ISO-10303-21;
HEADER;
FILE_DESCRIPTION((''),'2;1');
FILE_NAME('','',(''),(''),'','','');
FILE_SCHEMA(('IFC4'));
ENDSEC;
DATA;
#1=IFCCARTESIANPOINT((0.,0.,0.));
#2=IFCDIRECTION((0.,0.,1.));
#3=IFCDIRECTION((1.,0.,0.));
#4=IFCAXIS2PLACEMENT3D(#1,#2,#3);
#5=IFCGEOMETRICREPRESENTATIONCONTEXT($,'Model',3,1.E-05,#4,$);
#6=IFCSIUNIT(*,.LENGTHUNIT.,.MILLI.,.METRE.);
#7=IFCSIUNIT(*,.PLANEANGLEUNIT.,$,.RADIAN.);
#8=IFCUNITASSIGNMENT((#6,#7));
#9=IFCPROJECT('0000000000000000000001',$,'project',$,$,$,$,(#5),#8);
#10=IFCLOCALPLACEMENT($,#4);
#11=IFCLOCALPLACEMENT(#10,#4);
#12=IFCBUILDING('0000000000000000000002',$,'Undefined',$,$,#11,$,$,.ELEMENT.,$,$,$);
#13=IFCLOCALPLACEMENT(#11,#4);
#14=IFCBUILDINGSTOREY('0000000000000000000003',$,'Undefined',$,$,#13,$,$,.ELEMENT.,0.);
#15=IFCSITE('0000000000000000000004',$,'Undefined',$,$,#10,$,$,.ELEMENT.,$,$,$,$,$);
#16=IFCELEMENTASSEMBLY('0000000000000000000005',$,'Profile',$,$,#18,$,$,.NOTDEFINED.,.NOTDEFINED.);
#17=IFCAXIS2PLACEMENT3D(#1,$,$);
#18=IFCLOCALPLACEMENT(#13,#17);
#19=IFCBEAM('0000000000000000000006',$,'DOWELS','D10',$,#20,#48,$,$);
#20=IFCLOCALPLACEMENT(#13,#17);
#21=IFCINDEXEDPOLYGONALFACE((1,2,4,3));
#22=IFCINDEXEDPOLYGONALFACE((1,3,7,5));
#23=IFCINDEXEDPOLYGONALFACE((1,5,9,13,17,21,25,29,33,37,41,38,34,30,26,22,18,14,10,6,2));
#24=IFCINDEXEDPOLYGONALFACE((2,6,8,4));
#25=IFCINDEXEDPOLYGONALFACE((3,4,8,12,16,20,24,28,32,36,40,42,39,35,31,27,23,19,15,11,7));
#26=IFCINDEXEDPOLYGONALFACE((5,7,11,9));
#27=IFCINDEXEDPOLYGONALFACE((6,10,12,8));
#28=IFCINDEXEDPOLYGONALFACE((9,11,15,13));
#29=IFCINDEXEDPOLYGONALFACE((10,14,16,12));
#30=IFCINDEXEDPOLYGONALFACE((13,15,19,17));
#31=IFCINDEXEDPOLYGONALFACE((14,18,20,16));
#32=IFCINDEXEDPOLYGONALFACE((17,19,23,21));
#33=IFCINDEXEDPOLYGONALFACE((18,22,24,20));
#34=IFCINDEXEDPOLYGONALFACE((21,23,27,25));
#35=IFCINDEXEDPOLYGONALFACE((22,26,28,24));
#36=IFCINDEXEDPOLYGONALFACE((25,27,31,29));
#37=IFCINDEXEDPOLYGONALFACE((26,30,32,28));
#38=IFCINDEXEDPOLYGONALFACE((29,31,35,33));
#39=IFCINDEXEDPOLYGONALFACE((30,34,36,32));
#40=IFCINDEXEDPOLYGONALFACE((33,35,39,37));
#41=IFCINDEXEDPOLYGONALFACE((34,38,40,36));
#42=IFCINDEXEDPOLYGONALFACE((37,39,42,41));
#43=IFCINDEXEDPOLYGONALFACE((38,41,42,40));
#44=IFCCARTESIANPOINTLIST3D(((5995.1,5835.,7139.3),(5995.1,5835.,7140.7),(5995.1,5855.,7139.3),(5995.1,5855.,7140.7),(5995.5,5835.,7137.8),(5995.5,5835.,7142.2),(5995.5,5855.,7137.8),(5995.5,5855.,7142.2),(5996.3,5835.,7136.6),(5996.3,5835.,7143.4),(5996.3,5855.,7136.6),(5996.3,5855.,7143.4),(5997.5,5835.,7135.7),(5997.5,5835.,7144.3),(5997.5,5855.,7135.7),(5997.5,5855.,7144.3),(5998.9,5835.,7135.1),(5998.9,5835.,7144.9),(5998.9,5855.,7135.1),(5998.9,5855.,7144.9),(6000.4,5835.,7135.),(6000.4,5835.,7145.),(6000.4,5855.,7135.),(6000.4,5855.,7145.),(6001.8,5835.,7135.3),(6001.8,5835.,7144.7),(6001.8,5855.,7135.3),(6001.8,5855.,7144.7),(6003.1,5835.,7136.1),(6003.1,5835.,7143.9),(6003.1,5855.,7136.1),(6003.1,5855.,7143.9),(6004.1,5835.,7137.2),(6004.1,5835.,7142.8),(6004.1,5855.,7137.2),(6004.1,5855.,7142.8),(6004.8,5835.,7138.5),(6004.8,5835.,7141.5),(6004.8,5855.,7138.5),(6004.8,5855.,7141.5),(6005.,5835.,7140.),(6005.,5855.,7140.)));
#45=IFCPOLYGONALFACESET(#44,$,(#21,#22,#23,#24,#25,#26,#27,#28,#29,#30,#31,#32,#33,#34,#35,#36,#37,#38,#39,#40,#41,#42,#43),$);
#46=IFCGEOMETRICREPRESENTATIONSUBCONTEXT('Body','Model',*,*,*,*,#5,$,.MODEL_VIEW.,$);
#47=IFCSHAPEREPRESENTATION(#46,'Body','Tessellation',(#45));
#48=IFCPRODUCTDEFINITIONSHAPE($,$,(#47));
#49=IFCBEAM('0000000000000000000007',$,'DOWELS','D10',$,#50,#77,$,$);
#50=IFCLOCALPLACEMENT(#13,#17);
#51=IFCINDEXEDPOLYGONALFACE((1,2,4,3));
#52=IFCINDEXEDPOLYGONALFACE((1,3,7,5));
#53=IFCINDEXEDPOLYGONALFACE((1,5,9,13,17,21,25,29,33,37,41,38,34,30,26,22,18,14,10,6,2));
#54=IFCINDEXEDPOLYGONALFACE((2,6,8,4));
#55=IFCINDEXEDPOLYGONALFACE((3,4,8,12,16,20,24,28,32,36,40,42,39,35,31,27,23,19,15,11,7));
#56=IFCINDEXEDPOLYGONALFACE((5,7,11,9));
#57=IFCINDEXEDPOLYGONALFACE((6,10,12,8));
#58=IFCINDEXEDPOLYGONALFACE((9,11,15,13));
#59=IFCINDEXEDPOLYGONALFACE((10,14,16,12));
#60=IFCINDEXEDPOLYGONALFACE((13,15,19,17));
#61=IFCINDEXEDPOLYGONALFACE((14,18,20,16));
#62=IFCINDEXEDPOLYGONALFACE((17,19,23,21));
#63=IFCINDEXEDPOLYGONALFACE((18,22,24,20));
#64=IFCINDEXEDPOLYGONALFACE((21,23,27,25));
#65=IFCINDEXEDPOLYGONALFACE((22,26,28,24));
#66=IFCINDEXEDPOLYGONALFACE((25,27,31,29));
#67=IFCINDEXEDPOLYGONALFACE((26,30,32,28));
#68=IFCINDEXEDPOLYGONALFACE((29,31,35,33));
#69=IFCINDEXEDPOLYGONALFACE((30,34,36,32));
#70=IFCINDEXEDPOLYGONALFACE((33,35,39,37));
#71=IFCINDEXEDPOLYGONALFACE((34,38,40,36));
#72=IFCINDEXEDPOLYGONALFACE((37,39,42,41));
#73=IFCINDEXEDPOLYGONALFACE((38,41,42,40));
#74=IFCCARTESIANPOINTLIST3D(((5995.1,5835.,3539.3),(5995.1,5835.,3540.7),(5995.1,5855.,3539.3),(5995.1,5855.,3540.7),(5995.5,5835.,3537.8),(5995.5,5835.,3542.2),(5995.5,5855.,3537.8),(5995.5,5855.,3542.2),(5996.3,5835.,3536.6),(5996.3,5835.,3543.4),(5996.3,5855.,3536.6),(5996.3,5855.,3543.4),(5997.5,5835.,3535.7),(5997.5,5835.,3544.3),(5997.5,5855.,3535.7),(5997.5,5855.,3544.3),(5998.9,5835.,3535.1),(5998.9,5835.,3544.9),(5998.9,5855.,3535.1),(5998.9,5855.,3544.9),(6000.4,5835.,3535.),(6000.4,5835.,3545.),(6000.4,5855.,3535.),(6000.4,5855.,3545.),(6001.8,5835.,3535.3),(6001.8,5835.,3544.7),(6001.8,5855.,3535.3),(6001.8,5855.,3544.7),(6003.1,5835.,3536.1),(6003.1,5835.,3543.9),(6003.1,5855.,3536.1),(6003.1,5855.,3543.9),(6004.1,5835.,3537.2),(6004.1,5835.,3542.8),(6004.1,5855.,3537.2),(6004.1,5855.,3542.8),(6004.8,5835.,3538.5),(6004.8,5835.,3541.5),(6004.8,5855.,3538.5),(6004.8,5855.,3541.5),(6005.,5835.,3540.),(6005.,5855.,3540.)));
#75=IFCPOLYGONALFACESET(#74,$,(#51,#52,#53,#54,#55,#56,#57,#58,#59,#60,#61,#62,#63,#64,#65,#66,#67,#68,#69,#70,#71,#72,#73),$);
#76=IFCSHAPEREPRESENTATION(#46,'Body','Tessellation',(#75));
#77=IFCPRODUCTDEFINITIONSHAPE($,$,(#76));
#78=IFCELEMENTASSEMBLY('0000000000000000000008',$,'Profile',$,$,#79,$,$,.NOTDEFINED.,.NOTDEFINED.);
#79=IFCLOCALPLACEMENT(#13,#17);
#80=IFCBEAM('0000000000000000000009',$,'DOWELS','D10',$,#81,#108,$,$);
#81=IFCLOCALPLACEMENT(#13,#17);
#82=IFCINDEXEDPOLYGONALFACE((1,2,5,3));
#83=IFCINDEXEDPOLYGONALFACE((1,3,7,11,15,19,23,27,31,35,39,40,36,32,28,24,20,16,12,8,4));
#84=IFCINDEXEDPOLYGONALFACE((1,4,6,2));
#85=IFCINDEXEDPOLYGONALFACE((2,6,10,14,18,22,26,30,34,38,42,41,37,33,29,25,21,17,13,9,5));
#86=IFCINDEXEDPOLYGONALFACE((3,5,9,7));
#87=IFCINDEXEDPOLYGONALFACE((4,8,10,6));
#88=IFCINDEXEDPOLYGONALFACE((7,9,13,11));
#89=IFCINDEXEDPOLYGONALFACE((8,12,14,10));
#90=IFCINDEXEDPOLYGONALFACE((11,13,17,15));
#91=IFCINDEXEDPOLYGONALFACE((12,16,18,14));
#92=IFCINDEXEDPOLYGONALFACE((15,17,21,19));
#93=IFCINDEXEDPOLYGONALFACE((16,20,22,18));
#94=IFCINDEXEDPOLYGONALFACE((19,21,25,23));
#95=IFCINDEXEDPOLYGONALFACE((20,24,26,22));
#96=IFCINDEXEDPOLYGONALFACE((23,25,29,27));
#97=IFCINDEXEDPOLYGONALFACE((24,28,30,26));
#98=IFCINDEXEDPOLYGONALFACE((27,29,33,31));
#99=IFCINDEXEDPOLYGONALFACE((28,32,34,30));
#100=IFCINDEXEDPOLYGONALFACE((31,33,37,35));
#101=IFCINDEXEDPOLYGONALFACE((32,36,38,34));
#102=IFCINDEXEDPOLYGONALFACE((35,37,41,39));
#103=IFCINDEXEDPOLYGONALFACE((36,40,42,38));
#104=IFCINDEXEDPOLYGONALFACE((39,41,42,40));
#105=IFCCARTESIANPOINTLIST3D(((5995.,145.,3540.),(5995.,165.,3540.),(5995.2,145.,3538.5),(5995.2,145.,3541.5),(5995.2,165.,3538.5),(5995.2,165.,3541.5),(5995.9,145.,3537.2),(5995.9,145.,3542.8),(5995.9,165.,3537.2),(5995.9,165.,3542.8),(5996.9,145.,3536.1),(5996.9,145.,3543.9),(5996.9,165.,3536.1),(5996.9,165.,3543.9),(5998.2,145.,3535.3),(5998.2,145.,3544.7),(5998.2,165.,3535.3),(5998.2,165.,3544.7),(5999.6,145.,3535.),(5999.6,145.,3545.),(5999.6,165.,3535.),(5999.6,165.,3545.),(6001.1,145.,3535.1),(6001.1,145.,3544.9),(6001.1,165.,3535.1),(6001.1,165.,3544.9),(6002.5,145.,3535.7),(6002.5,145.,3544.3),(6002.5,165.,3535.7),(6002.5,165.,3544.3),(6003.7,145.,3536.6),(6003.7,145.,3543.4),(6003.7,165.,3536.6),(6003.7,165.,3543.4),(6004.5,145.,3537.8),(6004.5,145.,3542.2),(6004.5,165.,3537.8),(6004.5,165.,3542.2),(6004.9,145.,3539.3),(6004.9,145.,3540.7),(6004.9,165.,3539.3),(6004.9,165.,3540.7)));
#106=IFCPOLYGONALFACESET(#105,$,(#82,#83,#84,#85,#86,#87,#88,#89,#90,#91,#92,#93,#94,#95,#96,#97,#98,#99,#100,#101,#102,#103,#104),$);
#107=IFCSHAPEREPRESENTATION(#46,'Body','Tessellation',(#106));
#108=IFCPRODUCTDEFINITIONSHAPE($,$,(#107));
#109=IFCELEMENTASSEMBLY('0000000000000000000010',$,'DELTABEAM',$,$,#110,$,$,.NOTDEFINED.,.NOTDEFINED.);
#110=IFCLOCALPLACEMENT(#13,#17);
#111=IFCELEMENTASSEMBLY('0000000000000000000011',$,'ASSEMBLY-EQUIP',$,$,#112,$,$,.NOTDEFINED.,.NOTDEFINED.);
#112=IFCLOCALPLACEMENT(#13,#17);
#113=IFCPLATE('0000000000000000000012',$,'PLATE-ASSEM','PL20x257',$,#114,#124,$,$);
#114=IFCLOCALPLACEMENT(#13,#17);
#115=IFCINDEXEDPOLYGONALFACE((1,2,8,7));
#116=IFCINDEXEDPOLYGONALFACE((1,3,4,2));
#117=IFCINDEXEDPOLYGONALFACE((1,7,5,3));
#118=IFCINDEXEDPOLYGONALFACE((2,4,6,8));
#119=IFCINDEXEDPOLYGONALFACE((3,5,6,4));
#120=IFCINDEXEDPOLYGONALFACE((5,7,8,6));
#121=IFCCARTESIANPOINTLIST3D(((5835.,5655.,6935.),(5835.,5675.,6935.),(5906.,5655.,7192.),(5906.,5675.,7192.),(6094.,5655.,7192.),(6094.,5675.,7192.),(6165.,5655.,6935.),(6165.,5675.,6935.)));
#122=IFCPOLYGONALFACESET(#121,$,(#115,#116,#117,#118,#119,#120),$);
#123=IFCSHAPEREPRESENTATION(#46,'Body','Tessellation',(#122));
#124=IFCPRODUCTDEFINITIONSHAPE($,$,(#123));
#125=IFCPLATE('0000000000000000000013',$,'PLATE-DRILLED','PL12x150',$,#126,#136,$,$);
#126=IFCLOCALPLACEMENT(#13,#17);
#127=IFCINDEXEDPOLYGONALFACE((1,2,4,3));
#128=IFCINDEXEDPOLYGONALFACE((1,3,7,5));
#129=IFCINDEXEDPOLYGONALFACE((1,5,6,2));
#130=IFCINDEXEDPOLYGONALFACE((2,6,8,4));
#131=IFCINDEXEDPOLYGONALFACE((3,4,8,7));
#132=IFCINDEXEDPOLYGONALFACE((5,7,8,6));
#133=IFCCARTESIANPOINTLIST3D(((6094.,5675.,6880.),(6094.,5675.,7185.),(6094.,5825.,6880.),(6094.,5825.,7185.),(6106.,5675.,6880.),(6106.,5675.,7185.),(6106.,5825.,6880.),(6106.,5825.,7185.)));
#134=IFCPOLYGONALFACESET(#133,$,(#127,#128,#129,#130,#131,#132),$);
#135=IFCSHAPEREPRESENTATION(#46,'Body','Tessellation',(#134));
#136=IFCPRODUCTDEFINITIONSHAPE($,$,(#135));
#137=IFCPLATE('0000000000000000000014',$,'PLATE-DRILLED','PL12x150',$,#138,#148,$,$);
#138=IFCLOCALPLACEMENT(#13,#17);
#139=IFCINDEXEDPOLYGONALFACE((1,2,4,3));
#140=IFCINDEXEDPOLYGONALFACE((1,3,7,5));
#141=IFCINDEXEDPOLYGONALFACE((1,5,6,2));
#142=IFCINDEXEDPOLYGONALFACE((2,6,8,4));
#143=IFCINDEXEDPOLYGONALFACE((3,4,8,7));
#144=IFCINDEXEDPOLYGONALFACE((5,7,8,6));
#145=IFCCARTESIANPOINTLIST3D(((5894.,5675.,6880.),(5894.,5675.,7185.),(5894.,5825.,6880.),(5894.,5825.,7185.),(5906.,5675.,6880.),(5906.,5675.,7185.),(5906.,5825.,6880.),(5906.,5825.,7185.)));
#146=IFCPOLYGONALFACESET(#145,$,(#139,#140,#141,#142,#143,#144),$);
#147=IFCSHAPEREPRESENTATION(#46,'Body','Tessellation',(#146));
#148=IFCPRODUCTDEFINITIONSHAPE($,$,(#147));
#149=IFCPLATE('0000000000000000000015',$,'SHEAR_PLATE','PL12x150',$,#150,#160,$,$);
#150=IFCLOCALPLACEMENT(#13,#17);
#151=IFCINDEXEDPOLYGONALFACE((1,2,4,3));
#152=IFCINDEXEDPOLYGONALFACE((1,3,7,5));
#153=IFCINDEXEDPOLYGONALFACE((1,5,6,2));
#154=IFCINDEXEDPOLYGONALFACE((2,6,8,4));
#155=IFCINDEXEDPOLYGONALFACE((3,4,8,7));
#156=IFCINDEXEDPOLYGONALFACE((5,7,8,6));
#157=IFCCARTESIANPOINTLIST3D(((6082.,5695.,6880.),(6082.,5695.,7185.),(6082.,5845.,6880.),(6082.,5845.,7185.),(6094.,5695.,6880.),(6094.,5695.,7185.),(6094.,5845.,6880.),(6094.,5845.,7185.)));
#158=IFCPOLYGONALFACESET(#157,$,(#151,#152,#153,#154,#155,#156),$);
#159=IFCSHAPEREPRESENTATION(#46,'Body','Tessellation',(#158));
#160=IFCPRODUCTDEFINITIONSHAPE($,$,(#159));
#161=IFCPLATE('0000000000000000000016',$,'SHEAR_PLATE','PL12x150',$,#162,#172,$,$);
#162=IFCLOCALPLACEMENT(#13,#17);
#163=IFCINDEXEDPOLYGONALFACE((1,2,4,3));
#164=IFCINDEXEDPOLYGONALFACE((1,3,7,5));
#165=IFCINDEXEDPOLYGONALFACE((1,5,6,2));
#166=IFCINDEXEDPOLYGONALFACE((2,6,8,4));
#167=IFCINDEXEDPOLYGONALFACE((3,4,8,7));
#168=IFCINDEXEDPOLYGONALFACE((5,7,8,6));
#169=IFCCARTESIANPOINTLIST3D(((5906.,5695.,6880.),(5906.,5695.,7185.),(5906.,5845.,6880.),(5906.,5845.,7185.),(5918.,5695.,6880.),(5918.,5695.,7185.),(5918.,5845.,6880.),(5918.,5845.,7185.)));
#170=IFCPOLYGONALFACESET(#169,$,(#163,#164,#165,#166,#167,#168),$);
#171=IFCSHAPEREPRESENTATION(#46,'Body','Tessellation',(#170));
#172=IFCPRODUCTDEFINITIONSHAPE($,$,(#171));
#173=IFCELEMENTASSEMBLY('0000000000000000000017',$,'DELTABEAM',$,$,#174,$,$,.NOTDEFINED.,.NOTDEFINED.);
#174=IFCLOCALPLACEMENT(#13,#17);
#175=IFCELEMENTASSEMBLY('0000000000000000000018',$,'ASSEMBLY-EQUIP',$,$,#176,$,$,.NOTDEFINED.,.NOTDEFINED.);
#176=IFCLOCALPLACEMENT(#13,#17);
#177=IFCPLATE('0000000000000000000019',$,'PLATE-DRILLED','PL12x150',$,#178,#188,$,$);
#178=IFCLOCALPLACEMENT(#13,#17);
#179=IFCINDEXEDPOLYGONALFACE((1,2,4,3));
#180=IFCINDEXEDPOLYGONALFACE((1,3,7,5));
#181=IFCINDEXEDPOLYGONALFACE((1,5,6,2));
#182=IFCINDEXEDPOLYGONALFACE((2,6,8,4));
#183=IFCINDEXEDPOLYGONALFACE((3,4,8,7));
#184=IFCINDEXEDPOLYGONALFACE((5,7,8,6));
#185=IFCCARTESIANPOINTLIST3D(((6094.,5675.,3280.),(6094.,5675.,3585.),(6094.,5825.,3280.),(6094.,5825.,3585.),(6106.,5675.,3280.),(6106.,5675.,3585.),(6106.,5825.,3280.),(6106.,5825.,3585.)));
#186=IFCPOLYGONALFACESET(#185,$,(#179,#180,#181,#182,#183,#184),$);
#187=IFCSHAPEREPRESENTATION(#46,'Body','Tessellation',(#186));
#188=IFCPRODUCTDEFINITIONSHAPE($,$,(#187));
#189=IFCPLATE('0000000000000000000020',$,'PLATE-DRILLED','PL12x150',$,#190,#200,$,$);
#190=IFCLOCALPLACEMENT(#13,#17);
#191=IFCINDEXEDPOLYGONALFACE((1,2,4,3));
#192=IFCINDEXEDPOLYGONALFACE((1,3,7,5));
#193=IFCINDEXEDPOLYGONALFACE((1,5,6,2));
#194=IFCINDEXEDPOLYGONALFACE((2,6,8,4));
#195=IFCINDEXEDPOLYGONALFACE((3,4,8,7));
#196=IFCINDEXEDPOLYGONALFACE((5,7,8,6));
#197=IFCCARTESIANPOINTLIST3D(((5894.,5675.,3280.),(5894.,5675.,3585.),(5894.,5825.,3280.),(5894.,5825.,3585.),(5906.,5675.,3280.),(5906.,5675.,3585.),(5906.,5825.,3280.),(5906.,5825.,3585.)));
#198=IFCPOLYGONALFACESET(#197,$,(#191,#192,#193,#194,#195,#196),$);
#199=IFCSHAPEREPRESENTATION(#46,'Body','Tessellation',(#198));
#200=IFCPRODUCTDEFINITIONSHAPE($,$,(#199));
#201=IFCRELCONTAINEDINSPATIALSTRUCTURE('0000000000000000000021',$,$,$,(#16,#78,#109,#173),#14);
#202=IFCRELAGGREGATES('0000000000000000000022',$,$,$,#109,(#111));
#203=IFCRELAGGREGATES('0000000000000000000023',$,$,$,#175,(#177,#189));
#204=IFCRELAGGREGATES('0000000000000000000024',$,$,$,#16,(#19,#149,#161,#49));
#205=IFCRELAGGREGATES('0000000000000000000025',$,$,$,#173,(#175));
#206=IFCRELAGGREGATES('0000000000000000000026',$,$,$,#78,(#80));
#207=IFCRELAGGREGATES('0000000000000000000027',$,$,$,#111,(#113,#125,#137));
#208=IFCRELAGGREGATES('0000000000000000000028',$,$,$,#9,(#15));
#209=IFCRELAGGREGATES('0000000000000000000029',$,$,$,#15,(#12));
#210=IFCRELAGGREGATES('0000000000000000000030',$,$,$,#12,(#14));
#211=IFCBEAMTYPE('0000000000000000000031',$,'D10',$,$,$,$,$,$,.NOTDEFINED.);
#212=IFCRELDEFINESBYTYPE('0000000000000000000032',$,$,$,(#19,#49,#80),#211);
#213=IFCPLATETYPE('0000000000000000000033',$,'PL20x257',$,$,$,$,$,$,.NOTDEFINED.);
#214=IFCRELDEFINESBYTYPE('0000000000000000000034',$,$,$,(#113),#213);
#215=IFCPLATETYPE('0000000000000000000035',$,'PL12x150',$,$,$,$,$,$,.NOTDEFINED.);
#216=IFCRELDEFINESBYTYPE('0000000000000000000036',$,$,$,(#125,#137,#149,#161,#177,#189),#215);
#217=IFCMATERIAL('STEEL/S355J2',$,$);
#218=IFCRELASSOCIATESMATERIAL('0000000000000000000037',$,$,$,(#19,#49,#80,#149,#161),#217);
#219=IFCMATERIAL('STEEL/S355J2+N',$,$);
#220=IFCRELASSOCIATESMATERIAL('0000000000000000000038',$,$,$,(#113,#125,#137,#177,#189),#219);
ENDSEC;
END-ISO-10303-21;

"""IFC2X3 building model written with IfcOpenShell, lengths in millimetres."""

from ifc_helpers import new_model, si_unit, frame, origin_with_axes, origin_2d_with_axis, place, context, subcontext, project, spatial, polyline, circle, outline, extrude, material, type_object, element, aggregate, save


model = new_model("IFC2X3")

# Units and contexts
model_context = context("Model", 3, precision=1e-05, world=origin_with_axes())
body_context = subcontext(model_context, "Body", "Model", "MODEL_VIEW")
ifc_project = project(units=[si_unit("LENGTHUNIT", "METRE", prefix="MILLI"), si_unit("PLANEANGLEUNIT", "RADIAN")], contexts=[model_context])

# Site, building, storey
site_placement = place(None, origin_with_axes())
site = spatial("IfcSite", under=ifc_project, at=site_placement, Name="Undefined", CompositionType="ELEMENT")
building_placement = place(site_placement, origin_with_axes())
building = spatial("IfcBuilding", under=site, at=building_placement, Name="Undefined", CompositionType="ELEMENT")
storey_placement = place(building_placement, origin_with_axes())
storey = spatial("IfcBuildingStorey", under=building, at=storey_placement, Name="Undefined", CompositionType="ELEMENT", Elevation=0.0)

# Element assembly, beams
assembly_1_placement = place(storey_placement, origin_with_axes())
assembly_1 = element("IfcElementAssembly", 1, at=assembly_1_placement, inside=storey, Name="Profile", AssemblyPlace="NOTDEFINED", PredefinedType="NOTDEFINED")
ifc_material_1 = material(Name="STEEL/S355J2")
beam_type_1 = type_object("IfcBeamType", Name="D10", PredefinedType="NOTDEFINED")
beam_1_placement = place(assembly_1_placement, frame((6000.0, 5835.0, 7140.0), z_axis=(0.0, 0.0, 1.0), x_axis=(0.0, 1.0, 0.0)))
beam_1 = element("IfcBeam", 2, at=beam_1_placement, type_object=beam_type_1, material=ifc_material_1, Name="DOWELS", Description="D10", context=body_context, shape_type="SweptSolid", body=[
    extrude(circle(Radius=5.0, at=origin_2d_with_axis()), frame((20.0, 0.0, 0.0), z_axis=(-1.0, 0.0, 0.0), x_axis=(0.0, -1.0, 0.0)), (0.0, 0.0, 1.0), 20.0),
])
beam_2_placement = place(assembly_1_placement, frame((6000.0, 5835.0, 3540.0), z_axis=(0.0, 0.0, 1.0), x_axis=(0.0, 1.0, 0.0)))
beam_2 = element("IfcBeam", 3, at=beam_2_placement, type_object=beam_type_1, material=ifc_material_1, Name="DOWELS", Description="D10", context=body_context, shape_type="SweptSolid", body=[
    extrude(circle(Radius=5.0, at=origin_2d_with_axis()), frame((20.0, 0.0, 0.0), z_axis=(-1.0, 0.0, 0.0), x_axis=(0.0, -1.0, 0.0)), (0.0, 0.0, 1.0), 20.0),
])

# Element assembly, beam
assembly_2_placement = place(storey_placement, origin_with_axes())
assembly_2 = element("IfcElementAssembly", 4, at=assembly_2_placement, inside=storey, Name="Profile", AssemblyPlace="NOTDEFINED", PredefinedType="NOTDEFINED")
beam_3_placement = place(assembly_2_placement, frame((6000.0, 165.0, 3540.0), z_axis=(0.0, 0.0, 1.0), x_axis=(0.0, -1.0, 0.0)))
beam_3 = element("IfcBeam", 5, at=beam_3_placement, type_object=beam_type_1, material=ifc_material_1, Name="DOWELS", Description="D10", context=body_context, shape_type="SweptSolid", body=[
    extrude(circle(Radius=5.0, at=origin_2d_with_axis()), frame((20.0, 0.0, 0.0), z_axis=(-1.0, 0.0, 0.0), x_axis=(0.0, -1.0, 0.0)), (0.0, 0.0, 1.0), 20.0),
])

# Element assemblies, plates
assembly_3_placement = place(storey_placement, origin_with_axes())
assembly_3 = element("IfcElementAssembly", 6, at=assembly_3_placement, inside=storey, Name="DELTABEAM", AssemblyPlace="NOTDEFINED", PredefinedType="NOTDEFINED")
assembly_4_placement = place(assembly_3_placement, origin_with_axes())
assembly_4 = element("IfcElementAssembly", 7, at=assembly_4_placement, Name="ASSEMBLY-EQUIP", AssemblyPlace="NOTDEFINED", PredefinedType="NOTDEFINED")
aggregate(assembly_3, [assembly_4])
ifc_material_2 = material(Name="STEEL/S355J2+N")
plate_type_1 = type_object("IfcPlateType", Name="PL20x257", PredefinedType="NOTDEFINED")
plate_1_placement = place(assembly_4_placement, frame((5835.0, 5665.0, 6935.0), z_axis=(0.0, -1.0, 0.0), x_axis=(1.0, 0.0, 0.0)))
plate_1 = element("IfcPlate", 8, at=plate_1_placement, type_object=plate_type_1, material=ifc_material_2, Name="PLATE-ASSEM", Description="PL20x257", context=body_context, shape_type="SweptSolid", body=[
    extrude(outline(polyline([(0.0, 0.0), (330.0, 0.0), (259.0, 257.0), (71.0, 257.0), (0.0, 0.0)])), frame((0.0, 0.0, -10.0), z_axis=(0.0, 0.0, 1.0), x_axis=(1.0, 0.0, 0.0)), (0.0, 0.0, 1.0), 20.0),
])
plate_type_2 = type_object("IfcPlateType", Name="PL12x150", PredefinedType="NOTDEFINED")
plate_2_placement = place(assembly_4_placement, frame((6100.0, 5675.0, 7185.0), z_axis=(-1.0, 0.0, 0.0), x_axis=(0.0, 1.0, 0.0)))
plate_2 = element("IfcPlate", 9, at=plate_2_placement, type_object=plate_type_2, material=ifc_material_2, Name="PLATE-DRILLED", Description="PL12x150", context=body_context, shape_type="SweptSolid", body=[
    extrude(outline(polyline([(0.0, 0.0), (150.0, 0.0), (150.0, 0.0), (150.0, 305.0), (150.0, 305.0), (0.0, 305.0), (0.0, 305.0), (0.0, 0.0)])), frame((0.0, 0.0, -6.0), z_axis=(0.0, 0.0, 1.0), x_axis=(1.0, 0.0, 0.0)), (0.0, 0.0, 1.0), 12.0),
])
plate_3_placement = place(assembly_4_placement, frame((5900.0, 5675.0, 7185.0), z_axis=(-1.0, 0.0, 0.0), x_axis=(0.0, 1.0, 0.0)))
plate_3 = element("IfcPlate", 10, at=plate_3_placement, type_object=plate_type_2, material=ifc_material_2, Name="PLATE-DRILLED", Description="PL12x150", context=body_context, shape_type="SweptSolid", body=[
    extrude(outline(polyline([(0.0, 0.0), (150.0, 0.0), (150.0, 0.0), (150.0, 305.0), (150.0, 305.0), (0.0, 305.0), (0.0, 305.0), (0.0, 0.0)])), frame((0.0, 0.0, -6.0), z_axis=(0.0, 0.0, 1.0), x_axis=(1.0, 0.0, 0.0)), (0.0, 0.0, 1.0), 12.0),
])

# Plates
plate_4_placement = place(assembly_1_placement, frame((6088.0, 5845.0, 7185.0), z_axis=(1.0, 0.0, 0.0), x_axis=(0.0, -1.0, 0.0)))
plate_4 = element("IfcPlate", 11, at=plate_4_placement, type_object=plate_type_2, material=ifc_material_1, Name="SHEAR_PLATE", Description="PL12x150", context=body_context, shape_type="SweptSolid", body=[
    extrude(outline(polyline([(0.0, 0.0), (150.0, 0.0), (150.0, 0.0), (150.0, 305.0), (150.0, 305.0), (0.0, 305.0), (0.0, 305.0), (0.0, 0.0)])), frame((0.0, 0.0, -6.0), z_axis=(0.0, 0.0, 1.0), x_axis=(1.0, 0.0, 0.0)), (0.0, 0.0, 1.0), 12.0),
])
plate_5_placement = place(assembly_1_placement, frame((5912.0, 5845.0, 7185.0), z_axis=(1.0, 0.0, 0.0), x_axis=(0.0, -1.0, 0.0)))
plate_5 = element("IfcPlate", 12, at=plate_5_placement, type_object=plate_type_2, material=ifc_material_1, Name="SHEAR_PLATE", Description="PL12x150", context=body_context, shape_type="SweptSolid", body=[
    extrude(outline(polyline([(0.0, 0.0), (150.0, 0.0), (150.0, 0.0), (150.0, 305.0), (150.0, 305.0), (0.0, 305.0), (0.0, 305.0), (0.0, 0.0)])), frame((0.0, 0.0, -6.0), z_axis=(0.0, 0.0, 1.0), x_axis=(1.0, 0.0, 0.0)), (0.0, 0.0, 1.0), 12.0),
])

# Element assemblies, plates
assembly_5_placement = place(storey_placement, origin_with_axes())
assembly_5 = element("IfcElementAssembly", 13, at=assembly_5_placement, inside=storey, Name="DELTABEAM", AssemblyPlace="NOTDEFINED", PredefinedType="NOTDEFINED")
assembly_6_placement = place(assembly_5_placement, origin_with_axes())
assembly_6 = element("IfcElementAssembly", 14, at=assembly_6_placement, Name="ASSEMBLY-EQUIP", AssemblyPlace="NOTDEFINED", PredefinedType="NOTDEFINED")
plate_6_placement = place(assembly_6_placement, frame((6100.0, 5675.0, 3585.0), z_axis=(-1.0, 0.0, 0.0), x_axis=(0.0, 1.0, 0.0)))
plate_6 = element("IfcPlate", 15, at=plate_6_placement, type_object=plate_type_2, material=ifc_material_2, Name="PLATE-DRILLED", Description="PL12x150", context=body_context, shape_type="SweptSolid", body=[
    extrude(outline(polyline([(0.0, 0.0), (150.0, 0.0), (150.0, 0.0), (150.0, 305.0), (150.0, 305.0), (0.0, 305.0), (0.0, 305.0), (0.0, 0.0)])), frame((0.0, 0.0, -6.0), z_axis=(0.0, 0.0, 1.0), x_axis=(1.0, 0.0, 0.0)), (0.0, 0.0, 1.0), 12.0),
])
plate_7_placement = place(assembly_6_placement, frame((5900.0, 5675.0, 3585.0), z_axis=(-1.0, 0.0, 0.0), x_axis=(0.0, 1.0, 0.0)))
plate_7 = element("IfcPlate", 16, at=plate_7_placement, type_object=plate_type_2, material=ifc_material_2, Name="PLATE-DRILLED", Description="PL12x150", context=body_context, shape_type="SweptSolid", body=[
    extrude(outline(polyline([(0.0, 0.0), (150.0, 0.0), (150.0, 0.0), (150.0, 305.0), (150.0, 305.0), (0.0, 305.0), (0.0, 305.0), (0.0, 0.0)])), frame((0.0, 0.0, -6.0), z_axis=(0.0, 0.0, 1.0), x_axis=(1.0, 0.0, 0.0)), (0.0, 0.0, 1.0), 12.0),
])
aggregate(assembly_6, [plate_6, plate_7])

aggregate(assembly_1, [beam_1, plate_4, plate_5, beam_2])

aggregate(assembly_5, [assembly_6])

aggregate(assembly_2, [beam_3])

aggregate(assembly_4, [plate_1, plate_2, plate_3])

save(model, "model.ifc")
